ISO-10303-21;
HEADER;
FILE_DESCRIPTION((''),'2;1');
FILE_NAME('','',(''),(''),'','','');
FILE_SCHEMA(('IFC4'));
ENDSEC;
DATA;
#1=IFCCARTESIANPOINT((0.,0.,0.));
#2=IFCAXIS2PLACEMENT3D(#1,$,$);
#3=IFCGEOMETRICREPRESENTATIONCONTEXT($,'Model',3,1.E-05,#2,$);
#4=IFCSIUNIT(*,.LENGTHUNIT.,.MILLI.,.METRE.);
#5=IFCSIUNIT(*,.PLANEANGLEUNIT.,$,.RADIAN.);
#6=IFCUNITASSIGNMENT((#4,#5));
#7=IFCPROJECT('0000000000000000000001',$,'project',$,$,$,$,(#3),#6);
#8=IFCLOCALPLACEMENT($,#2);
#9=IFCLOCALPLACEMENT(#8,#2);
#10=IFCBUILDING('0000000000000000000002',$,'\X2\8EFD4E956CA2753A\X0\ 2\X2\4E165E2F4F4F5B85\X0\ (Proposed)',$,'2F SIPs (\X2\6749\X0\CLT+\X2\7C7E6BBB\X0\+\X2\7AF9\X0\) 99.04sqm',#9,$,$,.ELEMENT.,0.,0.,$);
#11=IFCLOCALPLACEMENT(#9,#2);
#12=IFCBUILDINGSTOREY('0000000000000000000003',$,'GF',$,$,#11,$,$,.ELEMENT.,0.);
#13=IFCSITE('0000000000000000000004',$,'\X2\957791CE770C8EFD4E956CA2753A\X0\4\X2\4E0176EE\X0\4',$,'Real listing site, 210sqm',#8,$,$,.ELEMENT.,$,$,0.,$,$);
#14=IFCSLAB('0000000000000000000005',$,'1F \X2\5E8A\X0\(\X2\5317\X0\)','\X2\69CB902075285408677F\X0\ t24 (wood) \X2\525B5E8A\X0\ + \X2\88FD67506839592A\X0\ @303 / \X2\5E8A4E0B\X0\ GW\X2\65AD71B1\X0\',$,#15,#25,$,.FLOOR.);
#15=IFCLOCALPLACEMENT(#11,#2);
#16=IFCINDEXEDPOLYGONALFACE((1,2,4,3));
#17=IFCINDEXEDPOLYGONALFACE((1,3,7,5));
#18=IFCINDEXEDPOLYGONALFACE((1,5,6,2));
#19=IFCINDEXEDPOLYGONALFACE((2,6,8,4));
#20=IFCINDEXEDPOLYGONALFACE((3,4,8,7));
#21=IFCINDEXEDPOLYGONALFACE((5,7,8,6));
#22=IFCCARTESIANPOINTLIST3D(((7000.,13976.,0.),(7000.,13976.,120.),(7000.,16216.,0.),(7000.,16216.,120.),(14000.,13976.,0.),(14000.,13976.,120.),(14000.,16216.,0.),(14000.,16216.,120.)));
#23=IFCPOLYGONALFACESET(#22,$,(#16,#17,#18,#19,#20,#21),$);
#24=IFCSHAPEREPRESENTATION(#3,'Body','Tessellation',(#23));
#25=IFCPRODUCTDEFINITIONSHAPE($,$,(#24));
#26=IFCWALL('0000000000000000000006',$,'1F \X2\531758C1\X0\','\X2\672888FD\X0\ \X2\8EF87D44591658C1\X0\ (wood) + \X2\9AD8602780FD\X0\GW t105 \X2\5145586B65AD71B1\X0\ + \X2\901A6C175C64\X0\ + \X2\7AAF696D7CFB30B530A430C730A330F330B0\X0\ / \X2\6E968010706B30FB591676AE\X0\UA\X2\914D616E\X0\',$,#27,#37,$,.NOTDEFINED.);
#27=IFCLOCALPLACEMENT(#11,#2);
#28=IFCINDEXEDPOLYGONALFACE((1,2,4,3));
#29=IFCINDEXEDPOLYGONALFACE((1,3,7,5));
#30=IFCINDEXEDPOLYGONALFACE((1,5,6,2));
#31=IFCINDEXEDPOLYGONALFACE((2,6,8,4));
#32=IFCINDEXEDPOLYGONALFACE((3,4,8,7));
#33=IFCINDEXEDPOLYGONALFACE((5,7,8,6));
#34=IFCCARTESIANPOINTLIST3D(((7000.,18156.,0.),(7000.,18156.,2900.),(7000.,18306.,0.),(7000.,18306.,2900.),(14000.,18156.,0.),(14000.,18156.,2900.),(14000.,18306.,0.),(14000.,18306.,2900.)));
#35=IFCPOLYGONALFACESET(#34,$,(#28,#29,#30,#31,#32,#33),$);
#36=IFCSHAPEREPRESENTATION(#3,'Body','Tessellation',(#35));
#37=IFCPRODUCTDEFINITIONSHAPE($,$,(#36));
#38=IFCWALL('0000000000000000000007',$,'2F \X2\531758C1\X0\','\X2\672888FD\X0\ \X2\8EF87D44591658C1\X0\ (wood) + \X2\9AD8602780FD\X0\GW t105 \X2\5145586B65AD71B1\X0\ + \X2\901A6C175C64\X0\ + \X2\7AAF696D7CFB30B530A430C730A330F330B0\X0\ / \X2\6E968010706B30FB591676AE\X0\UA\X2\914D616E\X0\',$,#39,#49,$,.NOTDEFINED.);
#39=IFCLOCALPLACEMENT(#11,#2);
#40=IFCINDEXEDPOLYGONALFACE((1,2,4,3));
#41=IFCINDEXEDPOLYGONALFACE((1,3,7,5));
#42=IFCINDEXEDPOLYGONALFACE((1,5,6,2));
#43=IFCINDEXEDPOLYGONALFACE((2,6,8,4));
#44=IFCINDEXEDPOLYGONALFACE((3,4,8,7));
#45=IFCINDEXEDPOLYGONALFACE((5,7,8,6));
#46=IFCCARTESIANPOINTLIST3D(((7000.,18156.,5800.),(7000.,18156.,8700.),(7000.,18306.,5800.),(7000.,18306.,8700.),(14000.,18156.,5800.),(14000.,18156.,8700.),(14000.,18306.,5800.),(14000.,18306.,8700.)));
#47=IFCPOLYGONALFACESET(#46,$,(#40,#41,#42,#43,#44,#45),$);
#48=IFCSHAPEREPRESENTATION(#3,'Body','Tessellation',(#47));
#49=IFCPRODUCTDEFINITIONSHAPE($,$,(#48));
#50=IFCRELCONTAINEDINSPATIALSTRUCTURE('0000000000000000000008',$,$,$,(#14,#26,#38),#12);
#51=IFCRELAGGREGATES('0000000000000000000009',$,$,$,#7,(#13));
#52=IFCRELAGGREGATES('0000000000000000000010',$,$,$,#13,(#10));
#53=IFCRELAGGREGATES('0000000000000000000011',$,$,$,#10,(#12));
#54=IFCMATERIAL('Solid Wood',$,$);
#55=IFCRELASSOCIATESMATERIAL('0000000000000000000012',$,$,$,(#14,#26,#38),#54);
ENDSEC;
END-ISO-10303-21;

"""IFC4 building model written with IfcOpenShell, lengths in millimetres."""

from ifc_helpers import new_model, si_unit, frame, frame_2d, origin, place, context, project, spatial, rectangle, extrude, material, element, save


model = new_model("IFC4")

# Units and contexts
model_context = context("Model", 3, precision=1e-05, world=origin())
ifc_project = project(units=[si_unit("LENGTHUNIT", "METRE", prefix="MILLI"), si_unit("PLANEANGLEUNIT", "RADIAN")], contexts=[model_context])

# Site, building, storey
site_placement = place(None, origin())
site = spatial("IfcSite", under=ifc_project, at=site_placement, Name="長野県軽井沢町4丁目4", ObjectType="Real listing site, 210sqm", CompositionType="ELEMENT", RefElevation=0.0)
building_placement = place(site_placement, origin())
building = spatial("IfcBuilding", under=site, at=building_placement, Name="軽井沢町 2世帯住宅 (Proposed)", ObjectType="2F SIPs (杉CLT+籾殻+竹) 99.04sqm", CompositionType="ELEMENT", ElevationOfRefHeight=0.0, ElevationOfTerrain=0.0)
storey_placement = place(building_placement, origin())
storey = spatial("IfcBuildingStorey", under=building, at=storey_placement, Name="GF", CompositionType="ELEMENT", Elevation=0.0)

# Slab
ifc_material_1 = material(Name="Solid Wood")
slab_1_placement = place(storey_placement, frame((3500.0, 6988.0, 0.0)))
element("IfcSlab", 1, at=slab_1_placement, inside=storey, material=ifc_material_1, Name="1F 床(北)", Description="構造用合板 t24 (wood) 剛床 + 製材根太 @303 / 床下 GW断熱", PredefinedType="FLOOR", context=model_context, shape_type="SweptSolid", body=[
    extrude(rectangle(XDim=7000.0, YDim=2240.0, at=frame_2d((3500.0, 1120.0))), frame((3500.0, 6988.0, 0.0)), (0.0, 0.0, 1.0), 120.0),
])

# Wall
wall_1_placement = place(storey_placement, frame((3500.0, 9078.0, 0.0)))
element("IfcWall", 2, at=wall_1_placement, inside=storey, material=ifc_material_1, Name="1F 北壁", Description="木製 軸組外壁 (wood) + 高性能GW t105 充填断熱 + 通気層 + 窯業系サイディング / 準耐火・外皮UA配慮", PredefinedType="NOTDEFINED", context=model_context, shape_type="SweptSolid", body=[
    extrude(rectangle(XDim=7000.0, YDim=150.0, at=frame_2d((3500.0, 75.0))), frame((3500.0, 9078.0, 0.0)), (0.0, 0.0, 1.0), 2900.0),
])

# Wall
wall_2_placement = place(storey_placement, frame((3500.0, 9078.0, 2900.0)))
element("IfcWall", 3, at=wall_2_placement, inside=storey, material=ifc_material_1, Name="2F 北壁", Description="木製 軸組外壁 (wood) + 高性能GW t105 充填断熱 + 通気層 + 窯業系サイディング / 準耐火・外皮UA配慮", PredefinedType="NOTDEFINED", context=model_context, shape_type="SweptSolid", body=[
    extrude(rectangle(XDim=7000.0, YDim=150.0, at=frame_2d((3500.0, 75.0))), frame((3500.0, 9078.0, 2900.0)), (0.0, 0.0, 1.0), 2900.0),
])

save(model, "model.ifc")
